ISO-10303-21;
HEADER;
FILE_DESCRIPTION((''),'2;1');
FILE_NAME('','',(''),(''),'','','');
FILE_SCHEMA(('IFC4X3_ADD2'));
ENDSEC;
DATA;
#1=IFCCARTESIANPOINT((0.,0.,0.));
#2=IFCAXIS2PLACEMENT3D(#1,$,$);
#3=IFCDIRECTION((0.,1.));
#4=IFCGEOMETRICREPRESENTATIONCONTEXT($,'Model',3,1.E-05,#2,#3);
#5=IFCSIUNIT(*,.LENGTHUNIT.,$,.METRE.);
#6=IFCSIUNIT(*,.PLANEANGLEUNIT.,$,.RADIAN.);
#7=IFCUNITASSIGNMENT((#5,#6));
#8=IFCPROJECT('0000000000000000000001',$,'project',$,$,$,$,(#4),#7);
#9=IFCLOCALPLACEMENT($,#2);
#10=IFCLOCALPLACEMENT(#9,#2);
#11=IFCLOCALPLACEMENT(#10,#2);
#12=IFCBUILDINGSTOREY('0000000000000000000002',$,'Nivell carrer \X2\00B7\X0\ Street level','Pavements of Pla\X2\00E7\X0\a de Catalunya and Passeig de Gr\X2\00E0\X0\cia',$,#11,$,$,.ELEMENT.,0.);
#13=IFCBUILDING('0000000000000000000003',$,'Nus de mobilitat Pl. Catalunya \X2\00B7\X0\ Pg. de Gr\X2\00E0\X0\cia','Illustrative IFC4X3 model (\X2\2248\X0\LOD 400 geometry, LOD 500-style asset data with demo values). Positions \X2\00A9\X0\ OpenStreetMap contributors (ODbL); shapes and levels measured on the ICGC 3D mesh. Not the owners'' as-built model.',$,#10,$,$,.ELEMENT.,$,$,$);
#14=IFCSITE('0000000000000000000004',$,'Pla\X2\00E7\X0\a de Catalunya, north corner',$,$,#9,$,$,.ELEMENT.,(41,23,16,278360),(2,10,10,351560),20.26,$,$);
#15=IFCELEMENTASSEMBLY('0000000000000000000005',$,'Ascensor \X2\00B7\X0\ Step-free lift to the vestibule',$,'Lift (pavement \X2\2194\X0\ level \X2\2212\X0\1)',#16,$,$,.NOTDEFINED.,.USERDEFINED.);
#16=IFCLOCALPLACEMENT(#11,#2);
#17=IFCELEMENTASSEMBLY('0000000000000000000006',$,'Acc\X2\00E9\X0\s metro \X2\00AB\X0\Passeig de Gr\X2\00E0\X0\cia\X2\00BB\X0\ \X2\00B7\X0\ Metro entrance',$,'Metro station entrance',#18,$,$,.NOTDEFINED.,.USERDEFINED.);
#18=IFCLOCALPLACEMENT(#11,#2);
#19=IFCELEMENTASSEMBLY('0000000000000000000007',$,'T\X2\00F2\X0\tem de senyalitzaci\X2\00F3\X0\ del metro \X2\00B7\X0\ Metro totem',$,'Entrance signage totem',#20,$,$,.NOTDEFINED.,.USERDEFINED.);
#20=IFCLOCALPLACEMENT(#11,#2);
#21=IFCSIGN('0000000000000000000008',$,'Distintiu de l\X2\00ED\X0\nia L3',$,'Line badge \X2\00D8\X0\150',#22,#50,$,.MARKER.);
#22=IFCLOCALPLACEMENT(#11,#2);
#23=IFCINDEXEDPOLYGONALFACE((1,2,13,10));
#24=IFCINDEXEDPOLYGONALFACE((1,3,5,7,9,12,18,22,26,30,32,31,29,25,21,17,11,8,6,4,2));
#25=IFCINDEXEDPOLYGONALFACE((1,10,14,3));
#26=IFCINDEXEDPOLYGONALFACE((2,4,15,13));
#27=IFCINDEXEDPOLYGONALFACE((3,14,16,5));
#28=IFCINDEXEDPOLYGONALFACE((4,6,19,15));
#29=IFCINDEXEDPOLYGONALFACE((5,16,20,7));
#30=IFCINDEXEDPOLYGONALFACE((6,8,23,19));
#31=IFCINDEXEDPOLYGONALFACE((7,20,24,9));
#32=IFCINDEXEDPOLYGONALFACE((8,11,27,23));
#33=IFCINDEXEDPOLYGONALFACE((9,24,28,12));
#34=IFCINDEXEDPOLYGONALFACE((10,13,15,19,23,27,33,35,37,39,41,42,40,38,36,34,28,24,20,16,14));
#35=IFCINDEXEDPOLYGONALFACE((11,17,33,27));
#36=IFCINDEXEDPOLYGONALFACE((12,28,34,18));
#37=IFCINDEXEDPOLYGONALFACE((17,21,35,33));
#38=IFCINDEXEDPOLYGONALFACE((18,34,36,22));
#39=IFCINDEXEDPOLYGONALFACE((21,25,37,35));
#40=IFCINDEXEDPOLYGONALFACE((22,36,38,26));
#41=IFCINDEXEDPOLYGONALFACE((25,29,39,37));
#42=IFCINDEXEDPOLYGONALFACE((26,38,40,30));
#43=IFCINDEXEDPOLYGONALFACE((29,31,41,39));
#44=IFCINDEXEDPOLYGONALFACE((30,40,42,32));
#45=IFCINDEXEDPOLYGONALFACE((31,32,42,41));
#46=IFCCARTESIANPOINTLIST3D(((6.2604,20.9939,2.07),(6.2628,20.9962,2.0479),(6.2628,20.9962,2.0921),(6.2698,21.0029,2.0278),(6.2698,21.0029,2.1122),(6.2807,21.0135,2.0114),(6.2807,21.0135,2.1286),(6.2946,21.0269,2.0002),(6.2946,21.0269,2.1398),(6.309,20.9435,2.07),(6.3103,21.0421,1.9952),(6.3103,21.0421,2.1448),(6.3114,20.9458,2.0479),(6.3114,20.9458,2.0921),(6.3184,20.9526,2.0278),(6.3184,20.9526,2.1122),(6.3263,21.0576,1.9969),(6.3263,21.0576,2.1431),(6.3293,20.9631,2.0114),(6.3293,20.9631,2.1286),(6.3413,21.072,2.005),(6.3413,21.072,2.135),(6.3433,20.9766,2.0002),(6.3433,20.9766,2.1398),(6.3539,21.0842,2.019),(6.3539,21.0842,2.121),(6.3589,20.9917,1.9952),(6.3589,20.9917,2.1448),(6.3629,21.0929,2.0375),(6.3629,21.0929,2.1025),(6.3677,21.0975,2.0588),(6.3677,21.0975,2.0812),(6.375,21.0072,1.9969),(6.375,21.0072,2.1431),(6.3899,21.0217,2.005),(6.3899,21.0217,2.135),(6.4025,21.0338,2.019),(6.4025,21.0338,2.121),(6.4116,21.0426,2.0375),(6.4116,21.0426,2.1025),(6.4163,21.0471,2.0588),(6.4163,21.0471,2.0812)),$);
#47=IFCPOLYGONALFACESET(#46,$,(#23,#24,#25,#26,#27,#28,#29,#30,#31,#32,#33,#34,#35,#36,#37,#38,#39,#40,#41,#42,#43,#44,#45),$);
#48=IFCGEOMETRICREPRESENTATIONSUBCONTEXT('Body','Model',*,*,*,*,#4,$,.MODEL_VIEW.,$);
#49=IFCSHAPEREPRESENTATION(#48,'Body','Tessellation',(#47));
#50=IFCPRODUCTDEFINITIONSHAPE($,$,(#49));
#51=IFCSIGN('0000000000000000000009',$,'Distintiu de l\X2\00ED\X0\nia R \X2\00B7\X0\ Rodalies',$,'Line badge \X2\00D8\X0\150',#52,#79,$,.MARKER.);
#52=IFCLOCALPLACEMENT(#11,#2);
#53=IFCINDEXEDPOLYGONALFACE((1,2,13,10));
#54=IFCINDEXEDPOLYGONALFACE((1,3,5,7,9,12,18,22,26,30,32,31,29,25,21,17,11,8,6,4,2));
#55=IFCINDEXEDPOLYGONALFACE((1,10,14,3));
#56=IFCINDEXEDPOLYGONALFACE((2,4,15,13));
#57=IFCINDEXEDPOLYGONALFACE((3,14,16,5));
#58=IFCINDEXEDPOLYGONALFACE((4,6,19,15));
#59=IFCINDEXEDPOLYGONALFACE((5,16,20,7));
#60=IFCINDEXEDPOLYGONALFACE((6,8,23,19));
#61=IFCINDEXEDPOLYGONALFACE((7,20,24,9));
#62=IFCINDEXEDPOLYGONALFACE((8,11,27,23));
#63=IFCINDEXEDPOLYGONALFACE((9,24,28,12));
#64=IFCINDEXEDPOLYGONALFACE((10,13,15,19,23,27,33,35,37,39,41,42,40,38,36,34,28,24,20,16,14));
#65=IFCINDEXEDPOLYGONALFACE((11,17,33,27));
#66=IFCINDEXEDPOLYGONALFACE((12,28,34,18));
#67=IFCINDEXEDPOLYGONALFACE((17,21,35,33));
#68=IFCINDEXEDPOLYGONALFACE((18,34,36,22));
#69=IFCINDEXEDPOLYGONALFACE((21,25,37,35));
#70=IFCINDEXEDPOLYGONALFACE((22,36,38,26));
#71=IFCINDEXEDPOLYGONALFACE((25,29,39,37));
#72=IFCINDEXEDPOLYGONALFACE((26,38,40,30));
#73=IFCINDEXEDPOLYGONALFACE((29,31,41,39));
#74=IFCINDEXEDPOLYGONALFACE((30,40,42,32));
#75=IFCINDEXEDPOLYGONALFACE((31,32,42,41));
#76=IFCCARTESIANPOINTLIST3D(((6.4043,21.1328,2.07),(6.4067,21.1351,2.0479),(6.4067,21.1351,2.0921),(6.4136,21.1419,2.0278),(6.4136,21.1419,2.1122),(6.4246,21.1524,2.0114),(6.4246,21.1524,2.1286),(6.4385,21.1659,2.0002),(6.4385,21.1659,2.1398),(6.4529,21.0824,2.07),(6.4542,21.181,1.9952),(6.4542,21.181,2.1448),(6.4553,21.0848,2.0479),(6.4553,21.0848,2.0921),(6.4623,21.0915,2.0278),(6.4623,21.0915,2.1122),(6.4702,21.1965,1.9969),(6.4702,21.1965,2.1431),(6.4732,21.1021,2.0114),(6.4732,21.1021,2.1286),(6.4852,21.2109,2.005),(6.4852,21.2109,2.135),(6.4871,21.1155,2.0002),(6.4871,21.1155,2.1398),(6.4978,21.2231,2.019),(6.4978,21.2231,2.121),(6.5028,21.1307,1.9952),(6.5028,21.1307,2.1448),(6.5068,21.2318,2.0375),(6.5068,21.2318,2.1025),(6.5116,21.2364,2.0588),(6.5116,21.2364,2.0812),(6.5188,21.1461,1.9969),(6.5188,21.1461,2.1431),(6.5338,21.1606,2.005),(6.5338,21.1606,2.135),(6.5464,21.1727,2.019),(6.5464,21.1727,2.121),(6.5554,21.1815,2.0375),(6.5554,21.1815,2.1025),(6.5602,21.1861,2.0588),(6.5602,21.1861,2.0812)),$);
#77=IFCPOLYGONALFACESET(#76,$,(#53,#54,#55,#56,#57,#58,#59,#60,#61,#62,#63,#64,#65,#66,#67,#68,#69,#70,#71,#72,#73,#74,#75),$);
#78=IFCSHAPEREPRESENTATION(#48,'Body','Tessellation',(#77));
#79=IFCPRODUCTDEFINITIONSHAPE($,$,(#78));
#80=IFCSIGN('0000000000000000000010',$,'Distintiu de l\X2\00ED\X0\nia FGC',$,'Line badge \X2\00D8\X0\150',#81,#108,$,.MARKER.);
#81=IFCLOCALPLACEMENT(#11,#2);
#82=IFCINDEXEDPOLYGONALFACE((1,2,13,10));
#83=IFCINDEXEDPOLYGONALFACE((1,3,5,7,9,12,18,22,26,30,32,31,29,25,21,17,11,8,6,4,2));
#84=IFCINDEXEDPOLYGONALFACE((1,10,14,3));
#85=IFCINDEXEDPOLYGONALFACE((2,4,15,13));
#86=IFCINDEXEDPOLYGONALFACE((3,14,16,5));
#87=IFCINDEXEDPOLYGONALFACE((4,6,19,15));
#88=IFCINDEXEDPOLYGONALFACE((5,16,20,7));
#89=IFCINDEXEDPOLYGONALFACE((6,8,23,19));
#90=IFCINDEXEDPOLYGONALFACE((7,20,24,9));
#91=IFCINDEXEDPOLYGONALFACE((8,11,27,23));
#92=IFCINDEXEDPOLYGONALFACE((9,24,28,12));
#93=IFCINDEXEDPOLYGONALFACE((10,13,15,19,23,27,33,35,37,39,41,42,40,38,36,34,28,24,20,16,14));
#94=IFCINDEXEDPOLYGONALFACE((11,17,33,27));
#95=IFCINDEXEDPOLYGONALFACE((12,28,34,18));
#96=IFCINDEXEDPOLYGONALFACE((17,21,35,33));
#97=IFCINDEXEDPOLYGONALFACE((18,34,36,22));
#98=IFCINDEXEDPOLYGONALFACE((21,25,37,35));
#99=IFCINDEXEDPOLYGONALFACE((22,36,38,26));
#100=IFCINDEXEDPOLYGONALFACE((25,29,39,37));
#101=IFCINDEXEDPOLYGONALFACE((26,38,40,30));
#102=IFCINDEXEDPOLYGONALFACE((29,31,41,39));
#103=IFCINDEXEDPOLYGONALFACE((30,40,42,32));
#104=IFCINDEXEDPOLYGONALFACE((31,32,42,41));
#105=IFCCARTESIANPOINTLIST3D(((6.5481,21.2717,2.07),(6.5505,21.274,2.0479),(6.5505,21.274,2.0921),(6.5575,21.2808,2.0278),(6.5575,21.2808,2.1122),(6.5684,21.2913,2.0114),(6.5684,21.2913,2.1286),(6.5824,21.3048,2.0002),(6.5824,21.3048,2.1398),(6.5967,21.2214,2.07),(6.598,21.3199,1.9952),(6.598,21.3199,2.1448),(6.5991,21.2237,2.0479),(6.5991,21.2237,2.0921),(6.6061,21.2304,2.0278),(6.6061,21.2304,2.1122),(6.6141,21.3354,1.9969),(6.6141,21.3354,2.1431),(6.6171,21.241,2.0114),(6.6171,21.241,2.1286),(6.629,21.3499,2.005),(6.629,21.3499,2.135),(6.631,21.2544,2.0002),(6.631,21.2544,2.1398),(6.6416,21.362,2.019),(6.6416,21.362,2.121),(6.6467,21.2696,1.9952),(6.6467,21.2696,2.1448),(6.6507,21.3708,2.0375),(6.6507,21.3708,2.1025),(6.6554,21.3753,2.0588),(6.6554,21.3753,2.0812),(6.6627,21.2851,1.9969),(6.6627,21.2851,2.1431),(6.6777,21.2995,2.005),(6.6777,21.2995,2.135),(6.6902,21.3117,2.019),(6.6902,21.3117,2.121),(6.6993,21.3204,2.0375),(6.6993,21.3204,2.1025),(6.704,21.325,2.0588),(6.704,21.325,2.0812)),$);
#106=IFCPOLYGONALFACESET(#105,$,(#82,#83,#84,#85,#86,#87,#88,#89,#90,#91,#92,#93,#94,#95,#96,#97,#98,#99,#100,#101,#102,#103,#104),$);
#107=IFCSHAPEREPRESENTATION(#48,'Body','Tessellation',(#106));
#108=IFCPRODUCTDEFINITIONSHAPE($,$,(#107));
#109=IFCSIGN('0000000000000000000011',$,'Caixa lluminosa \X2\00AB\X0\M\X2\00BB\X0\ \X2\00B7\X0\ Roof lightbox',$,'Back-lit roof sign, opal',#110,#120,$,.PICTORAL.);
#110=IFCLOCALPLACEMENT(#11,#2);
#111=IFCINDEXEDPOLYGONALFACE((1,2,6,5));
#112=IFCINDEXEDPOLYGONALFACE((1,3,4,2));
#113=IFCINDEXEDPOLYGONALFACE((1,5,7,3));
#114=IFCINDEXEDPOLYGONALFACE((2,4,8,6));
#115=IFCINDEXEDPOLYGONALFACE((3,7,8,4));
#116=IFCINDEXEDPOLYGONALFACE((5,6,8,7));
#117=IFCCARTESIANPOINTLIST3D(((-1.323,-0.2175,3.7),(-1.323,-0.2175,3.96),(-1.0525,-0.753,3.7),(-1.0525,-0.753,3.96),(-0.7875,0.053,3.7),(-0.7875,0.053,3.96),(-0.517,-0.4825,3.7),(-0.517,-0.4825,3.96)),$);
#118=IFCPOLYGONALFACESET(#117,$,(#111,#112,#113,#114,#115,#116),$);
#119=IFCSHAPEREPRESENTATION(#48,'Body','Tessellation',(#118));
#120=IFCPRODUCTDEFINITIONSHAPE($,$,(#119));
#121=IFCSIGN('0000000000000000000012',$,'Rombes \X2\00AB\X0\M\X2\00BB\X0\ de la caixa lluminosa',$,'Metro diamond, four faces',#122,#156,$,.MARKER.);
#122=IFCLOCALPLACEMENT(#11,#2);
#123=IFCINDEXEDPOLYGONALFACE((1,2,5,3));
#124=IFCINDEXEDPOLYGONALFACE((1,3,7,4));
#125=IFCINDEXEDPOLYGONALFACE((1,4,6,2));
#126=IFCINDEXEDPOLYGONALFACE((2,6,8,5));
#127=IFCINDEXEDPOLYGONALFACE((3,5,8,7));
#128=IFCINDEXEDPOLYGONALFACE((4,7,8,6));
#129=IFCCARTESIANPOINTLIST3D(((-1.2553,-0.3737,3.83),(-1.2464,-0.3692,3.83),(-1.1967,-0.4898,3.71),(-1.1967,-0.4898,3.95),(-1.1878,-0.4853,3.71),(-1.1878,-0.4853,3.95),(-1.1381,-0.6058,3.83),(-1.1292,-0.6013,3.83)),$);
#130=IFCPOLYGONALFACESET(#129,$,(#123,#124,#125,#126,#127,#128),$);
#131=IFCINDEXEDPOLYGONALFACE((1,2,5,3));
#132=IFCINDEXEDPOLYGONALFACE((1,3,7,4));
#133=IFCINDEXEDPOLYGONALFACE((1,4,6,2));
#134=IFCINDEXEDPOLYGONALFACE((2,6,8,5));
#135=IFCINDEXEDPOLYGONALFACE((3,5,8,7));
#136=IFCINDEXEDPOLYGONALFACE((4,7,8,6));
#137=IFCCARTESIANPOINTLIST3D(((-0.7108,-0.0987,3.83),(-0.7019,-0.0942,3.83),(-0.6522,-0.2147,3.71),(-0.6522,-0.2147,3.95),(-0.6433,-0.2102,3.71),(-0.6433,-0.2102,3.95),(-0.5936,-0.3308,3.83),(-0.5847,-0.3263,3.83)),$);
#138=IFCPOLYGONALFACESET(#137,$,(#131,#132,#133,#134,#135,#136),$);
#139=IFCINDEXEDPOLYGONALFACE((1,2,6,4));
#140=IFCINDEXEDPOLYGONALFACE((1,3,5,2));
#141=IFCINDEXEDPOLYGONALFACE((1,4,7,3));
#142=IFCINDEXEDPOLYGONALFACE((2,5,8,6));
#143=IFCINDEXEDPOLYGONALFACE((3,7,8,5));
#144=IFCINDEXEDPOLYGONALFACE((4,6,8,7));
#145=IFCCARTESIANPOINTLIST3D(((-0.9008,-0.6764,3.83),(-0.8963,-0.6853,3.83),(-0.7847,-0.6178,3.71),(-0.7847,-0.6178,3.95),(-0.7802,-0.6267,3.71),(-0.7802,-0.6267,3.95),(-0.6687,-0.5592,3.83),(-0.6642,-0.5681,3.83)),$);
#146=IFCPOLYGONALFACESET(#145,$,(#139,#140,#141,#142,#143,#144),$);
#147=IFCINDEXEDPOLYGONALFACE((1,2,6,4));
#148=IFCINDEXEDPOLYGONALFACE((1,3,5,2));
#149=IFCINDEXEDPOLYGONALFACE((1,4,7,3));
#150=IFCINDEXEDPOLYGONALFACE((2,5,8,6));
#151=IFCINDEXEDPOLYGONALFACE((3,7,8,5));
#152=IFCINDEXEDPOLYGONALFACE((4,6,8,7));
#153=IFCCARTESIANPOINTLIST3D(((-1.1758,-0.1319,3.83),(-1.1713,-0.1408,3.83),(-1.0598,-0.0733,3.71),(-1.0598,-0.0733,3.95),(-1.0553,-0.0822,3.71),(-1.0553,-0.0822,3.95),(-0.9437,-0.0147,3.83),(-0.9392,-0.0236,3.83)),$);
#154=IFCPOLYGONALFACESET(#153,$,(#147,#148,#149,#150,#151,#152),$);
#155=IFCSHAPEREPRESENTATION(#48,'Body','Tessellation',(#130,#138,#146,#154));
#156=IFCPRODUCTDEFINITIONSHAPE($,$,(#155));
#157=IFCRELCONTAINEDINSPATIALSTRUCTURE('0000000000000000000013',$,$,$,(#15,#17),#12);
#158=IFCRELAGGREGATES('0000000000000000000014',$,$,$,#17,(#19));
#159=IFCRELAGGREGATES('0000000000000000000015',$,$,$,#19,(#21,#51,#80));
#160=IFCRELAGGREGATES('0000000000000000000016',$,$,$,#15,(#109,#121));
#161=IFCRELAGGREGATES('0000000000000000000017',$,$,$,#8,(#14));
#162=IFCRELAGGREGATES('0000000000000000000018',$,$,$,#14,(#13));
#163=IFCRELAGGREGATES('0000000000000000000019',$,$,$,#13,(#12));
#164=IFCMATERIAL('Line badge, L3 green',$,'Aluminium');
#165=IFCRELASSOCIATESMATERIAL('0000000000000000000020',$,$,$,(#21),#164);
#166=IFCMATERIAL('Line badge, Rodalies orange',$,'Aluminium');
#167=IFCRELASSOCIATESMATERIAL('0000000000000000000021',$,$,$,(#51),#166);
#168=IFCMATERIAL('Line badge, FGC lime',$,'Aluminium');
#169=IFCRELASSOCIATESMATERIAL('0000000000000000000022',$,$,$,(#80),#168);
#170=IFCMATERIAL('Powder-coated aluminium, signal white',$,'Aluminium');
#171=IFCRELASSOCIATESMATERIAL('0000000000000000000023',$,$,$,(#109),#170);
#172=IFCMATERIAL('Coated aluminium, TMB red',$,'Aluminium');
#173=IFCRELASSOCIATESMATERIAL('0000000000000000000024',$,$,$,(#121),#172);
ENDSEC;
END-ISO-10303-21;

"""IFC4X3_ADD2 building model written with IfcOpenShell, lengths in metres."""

from ifc_helpers import new_model, si_unit, direction, frame, frame_2d, origin, origin_2d_with_axis, place, context, subcontext, project, spatial, polyline, rectangle, circle, outline, extrude, material, element, aggregate, save


model = new_model("IFC4X3_ADD2")

# Units and contexts
model_context = context("Model", 3, precision=1e-05, world=origin(), true_north=direction((0.0, 1.0)))
body_context = subcontext(model_context, "Body", "Model", "MODEL_VIEW")
ifc_project = project(units=[si_unit("LENGTHUNIT", "METRE"), si_unit("PLANEANGLEUNIT", "RADIAN")], contexts=[model_context])

# Site, building, storey
site_placement = place(None, origin())
site = spatial("IfcSite", under=ifc_project, at=site_placement, Name="Plaça de Catalunya, north corner", CompositionType="ELEMENT", RefLatitude=(41, 23, 16, 278360), RefLongitude=(2, 10, 10, 351560), RefElevation=20.26)
building_placement = place(site_placement, origin())
building = spatial("IfcBuilding", under=site, at=building_placement, Name="Nus de mobilitat Pl. Catalunya · Pg. de Gràcia", Description="Illustrative IFC4X3 model (≈LOD 400 geometry, LOD 500-style asset data with demo values). Positions © OpenStreetMap contributors (ODbL); shapes and levels measured on the ICGC 3D mesh. Not the owners' as-built model.", CompositionType="ELEMENT")
storey_placement = place(building_placement, origin())
storey = spatial("IfcBuildingStorey", under=building, at=storey_placement, Name="Nivell carrer · Street level", Description="Pavements of Plaça de Catalunya and Passeig de Gràcia", CompositionType="ELEMENT", Elevation=0.0)

# Element assembly
assembly_1_placement = place(building_placement, origin())
assembly_1 = element("IfcElementAssembly", 1, at=assembly_1_placement, inside=storey, Name="Ascensor · Step-free lift to the vestibule", ObjectType="Lift (pavement ↔ level −1)", AssemblyPlace="NOTDEFINED", PredefinedType="USERDEFINED")

# Element assemblies
assembly_2_placement = place(building_placement, origin())
assembly_2 = element("IfcElementAssembly", 2, at=assembly_2_placement, inside=storey, Name="Accés metro «Passeig de Gràcia» · Metro entrance", ObjectType="Metro station entrance", AssemblyPlace="NOTDEFINED", PredefinedType="USERDEFINED")
assembly_3_placement = place(building_placement, origin())
assembly_3 = element("IfcElementAssembly", 3, at=assembly_3_placement, Name="Tòtem de senyalització del metro · Metro totem", ObjectType="Entrance signage totem", AssemblyPlace="NOTDEFINED", PredefinedType="USERDEFINED")

aggregate(assembly_2, [assembly_3])

# Signs
ifc_material_1 = material(Name="Coated aluminium, TMB red", Category="Aluminium")
ifc_material_2 = material(Name="Powder-coated aluminium, signal white", Category="Aluminium")
ifc_material_3 = material(Name="Line badge, L3 green", Category="Aluminium")
sign_1_placement = place(building_placement, origin())
sign_1 = element("IfcSign", 4, at=sign_1_placement, material=ifc_material_3, Name="Distintiu de línia L3", ObjectType="Line badge Ø150", PredefinedType="MARKER", context=body_context, shape_type="SweptSolid", body=[
    extrude(circle(Radius=0.075, at=origin_2d_with_axis()), frame((6.3143, 21.046, 2.07), z_axis=(0.694658, -0.71934, 0.0), x_axis=(-0.71934, -0.694658, 0.0)), (0.0, 0.0, 1.0), 0.07),
])
ifc_material_4 = material(Name="Line badge, Rodalies orange", Category="Aluminium")
sign_2_placement = place(building_placement, origin())
sign_2 = element("IfcSign", 5, at=sign_2_placement, material=ifc_material_4, Name="Distintiu de línia R · Rodalies", ObjectType="Line badge Ø150", PredefinedType="MARKER", context=body_context, shape_type="SweptSolid", body=[
    extrude(circle(Radius=0.075, at=origin_2d_with_axis()), frame((6.4582, 21.1849, 2.07), z_axis=(0.694658, -0.71934, 0.0), x_axis=(-0.71934, -0.694658, 0.0)), (0.0, 0.0, 1.0), 0.07),
])
ifc_material_5 = material(Name="Line badge, FGC lime", Category="Aluminium")
sign_3_placement = place(building_placement, origin())
sign_3 = element("IfcSign", 6, at=sign_3_placement, material=ifc_material_5, Name="Distintiu de línia FGC", ObjectType="Line badge Ø150", PredefinedType="MARKER", context=body_context, shape_type="SweptSolid", body=[
    extrude(circle(Radius=0.075, at=origin_2d_with_axis()), frame((6.6021, 21.3238, 2.07), z_axis=(0.694658, -0.71934, 0.0), x_axis=(-0.71934, -0.694658, 0.0)), (0.0, 0.0, 1.0), 0.07),
])
aggregate(assembly_3, [sign_1, sign_2, sign_3])
sign_4_placement = place(building_placement, origin())
sign_4 = element("IfcSign", 7, at=sign_4_placement, material=ifc_material_2, Name="Caixa lluminosa «M» · Roof lightbox", ObjectType="Back-lit roof sign, opal", PredefinedType="PICTORAL", context=body_context, shape_type="SweptSolid", body=[
    extrude(rectangle(XDim=0.6, YDim=0.6, at=frame_2d((0.0, 0.0), x_axis=(0.892586, 0.450878))), frame((-0.92, -0.35, 3.7)), (0.0, 0.0, 1.0), 0.26),
])
sign_5_placement = place(building_placement, origin())
sign_5 = element("IfcSign", 8, at=sign_5_placement, material=ifc_material_1, Name="Rombes «M» de la caixa lluminosa", ObjectType="Metro diamond, four faces", PredefinedType="MARKER", context=body_context, shape_type="SweptSolid", body=[
    extrude(outline(polyline([(-0.13, 3.83), (0.0, 3.71), (0.13, 3.83), (0.0, 3.95), (-0.13, 3.83)])), frame((-1.1967, -0.4898, 0.0), z_axis=(0.892586, 0.450878, 0.0), x_axis=(-0.450878, 0.892586, 0.0)), (0.0, 0.0, 1.0), 0.01),
    extrude(outline(polyline([(-0.13, 3.83), (0.0, 3.71), (0.13, 3.83), (0.0, 3.95), (-0.13, 3.83)])), frame((-0.6522, -0.2147, 0.0), z_axis=(0.892586, 0.450878, 0.0), x_axis=(-0.450878, 0.892586, 0.0)), (0.0, 0.0, 1.0), 0.01),
    extrude(outline(polyline([(-0.13, 3.83), (0.0, 3.71), (0.13, 3.83), (0.0, 3.95), (-0.13, 3.83)])), frame((-0.7847, -0.6178, 0.0), z_axis=(0.450878, -0.892586, 0.0), x_axis=(0.892586, 0.450878, 0.0)), (0.0, 0.0, 1.0), 0.01),
    extrude(outline(polyline([(-0.13, 3.83), (0.0, 3.71), (0.13, 3.83), (0.0, 3.95), (-0.13, 3.83)])), frame((-1.0598, -0.0733, 0.0), z_axis=(0.450878, -0.892586, 0.0), x_axis=(0.892586, 0.450878, 0.0)), (0.0, 0.0, 1.0), 0.01),
])
aggregate(assembly_1, [sign_4, sign_5])

save(model, "model.ifc")
